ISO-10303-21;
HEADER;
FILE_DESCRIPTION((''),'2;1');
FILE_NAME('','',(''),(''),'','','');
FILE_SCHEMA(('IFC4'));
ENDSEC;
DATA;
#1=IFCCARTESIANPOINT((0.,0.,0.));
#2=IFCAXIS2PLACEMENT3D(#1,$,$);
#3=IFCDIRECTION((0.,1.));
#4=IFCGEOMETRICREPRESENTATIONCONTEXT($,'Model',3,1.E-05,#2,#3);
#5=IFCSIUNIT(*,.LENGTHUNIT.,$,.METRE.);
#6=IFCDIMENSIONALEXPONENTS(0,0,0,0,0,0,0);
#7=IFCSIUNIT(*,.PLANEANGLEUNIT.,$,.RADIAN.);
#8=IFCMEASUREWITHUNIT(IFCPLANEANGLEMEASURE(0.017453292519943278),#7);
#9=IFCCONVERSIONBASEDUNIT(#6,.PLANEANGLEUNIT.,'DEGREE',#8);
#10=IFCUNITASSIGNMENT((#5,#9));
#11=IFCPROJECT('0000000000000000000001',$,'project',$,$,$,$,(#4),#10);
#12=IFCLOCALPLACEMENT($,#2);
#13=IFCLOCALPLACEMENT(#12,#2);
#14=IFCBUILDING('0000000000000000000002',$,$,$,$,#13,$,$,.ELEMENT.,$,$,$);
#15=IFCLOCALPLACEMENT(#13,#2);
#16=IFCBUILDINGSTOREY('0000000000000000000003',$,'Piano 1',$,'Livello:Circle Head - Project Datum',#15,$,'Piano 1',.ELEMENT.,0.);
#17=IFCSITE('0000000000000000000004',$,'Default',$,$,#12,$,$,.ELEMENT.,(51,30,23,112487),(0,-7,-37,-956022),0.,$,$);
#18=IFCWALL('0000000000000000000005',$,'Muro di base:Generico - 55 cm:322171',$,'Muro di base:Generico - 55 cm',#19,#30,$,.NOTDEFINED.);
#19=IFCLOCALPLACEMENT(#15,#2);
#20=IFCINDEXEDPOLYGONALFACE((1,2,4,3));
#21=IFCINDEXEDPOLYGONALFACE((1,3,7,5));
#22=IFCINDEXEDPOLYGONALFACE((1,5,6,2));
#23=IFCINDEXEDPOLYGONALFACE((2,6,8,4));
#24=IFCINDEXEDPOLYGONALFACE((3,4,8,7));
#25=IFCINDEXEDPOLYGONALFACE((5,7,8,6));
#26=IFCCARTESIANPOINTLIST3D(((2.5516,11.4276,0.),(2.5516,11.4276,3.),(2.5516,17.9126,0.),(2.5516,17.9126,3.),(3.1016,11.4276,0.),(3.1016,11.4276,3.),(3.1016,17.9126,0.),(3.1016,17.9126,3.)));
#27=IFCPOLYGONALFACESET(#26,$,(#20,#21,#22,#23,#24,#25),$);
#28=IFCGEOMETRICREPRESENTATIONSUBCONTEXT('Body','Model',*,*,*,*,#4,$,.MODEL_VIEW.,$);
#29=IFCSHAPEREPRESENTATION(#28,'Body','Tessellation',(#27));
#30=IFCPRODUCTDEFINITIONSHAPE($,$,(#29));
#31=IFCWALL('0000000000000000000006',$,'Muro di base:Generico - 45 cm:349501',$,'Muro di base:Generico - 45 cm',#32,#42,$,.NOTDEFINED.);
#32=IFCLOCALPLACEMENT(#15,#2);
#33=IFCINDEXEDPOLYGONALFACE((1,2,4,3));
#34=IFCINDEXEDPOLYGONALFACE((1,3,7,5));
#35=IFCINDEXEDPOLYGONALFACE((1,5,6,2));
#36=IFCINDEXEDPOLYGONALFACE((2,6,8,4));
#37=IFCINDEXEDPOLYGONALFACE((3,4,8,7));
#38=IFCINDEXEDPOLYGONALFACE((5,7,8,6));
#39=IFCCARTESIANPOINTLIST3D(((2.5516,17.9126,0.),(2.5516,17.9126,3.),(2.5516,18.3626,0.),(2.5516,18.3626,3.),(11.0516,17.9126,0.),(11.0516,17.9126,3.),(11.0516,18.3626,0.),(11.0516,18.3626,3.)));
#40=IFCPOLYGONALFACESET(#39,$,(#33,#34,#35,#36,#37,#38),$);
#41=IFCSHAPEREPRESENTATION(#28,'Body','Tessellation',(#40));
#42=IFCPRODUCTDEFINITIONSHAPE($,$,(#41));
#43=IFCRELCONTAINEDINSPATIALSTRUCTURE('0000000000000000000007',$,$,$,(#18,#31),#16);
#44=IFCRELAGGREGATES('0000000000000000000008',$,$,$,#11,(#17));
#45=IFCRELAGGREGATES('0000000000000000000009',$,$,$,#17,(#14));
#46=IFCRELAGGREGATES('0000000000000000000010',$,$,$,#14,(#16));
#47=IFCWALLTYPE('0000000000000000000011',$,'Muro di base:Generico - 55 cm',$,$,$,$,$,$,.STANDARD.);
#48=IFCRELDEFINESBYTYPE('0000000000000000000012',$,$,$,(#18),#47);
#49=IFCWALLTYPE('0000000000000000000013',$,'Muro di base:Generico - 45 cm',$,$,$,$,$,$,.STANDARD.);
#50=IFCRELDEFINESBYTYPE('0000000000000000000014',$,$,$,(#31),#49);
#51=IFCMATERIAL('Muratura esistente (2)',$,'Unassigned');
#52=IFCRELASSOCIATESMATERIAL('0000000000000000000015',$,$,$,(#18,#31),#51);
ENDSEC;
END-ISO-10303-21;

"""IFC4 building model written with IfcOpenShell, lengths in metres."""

from ifc_helpers import new_model, entity, si_unit, converted_unit, direction, frame, origin, place, context, subcontext, project, spatial, indexed_curve, outline, extrude, material, type_object, element, save


model = new_model("IFC4")

# Units and contexts
model_context = context("Model", 3, precision=1e-05, world=origin(), true_north=direction((0.0, 1.0)))
body_context = subcontext(model_context, "Body", "Model", "MODEL_VIEW")
ifc_project = project(units=[si_unit("LENGTHUNIT", "METRE"), converted_unit("PLANEANGLEUNIT", "DEGREE", entity("IfcPlaneAngleMeasure", 0.017453292519943278), si_unit("PLANEANGLEUNIT", "RADIAN"), dimensions=[0, 0, 0, 0, 0, 0, 0])], contexts=[model_context])

# Site, building, storey
site_placement = place(None, origin())
site = spatial("IfcSite", under=ifc_project, at=site_placement, Name="Default", CompositionType="ELEMENT", RefLatitude=(51, 30, 23, 112487), RefLongitude=(0, -7, -37, -956022), RefElevation=0.0)
building_placement = place(site_placement, origin())
building = spatial("IfcBuilding", under=site, at=building_placement, CompositionType="ELEMENT")
storey_placement = place(building_placement, origin())
storey = spatial("IfcBuildingStorey", under=building, at=storey_placement, Name="Piano 1", ObjectType="Livello:Circle Head - Project Datum", LongName="Piano 1", CompositionType="ELEMENT", Elevation=0.0)

# Walls
ifc_material = material(Name="Muratura esistente (2)", Category="Unassigned")
wall_type_1 = type_object("IfcWallType", Name="Muro di base:Generico - 55 cm", PredefinedType="STANDARD")
wall_1_placement = place(storey_placement, frame((2.8266, 17.9126, 0.0), z_axis=(0.0, 0.0, 1.0), x_axis=(0.0, -1.0, 0.0)))
element("IfcWall", 1, at=wall_1_placement, inside=storey, type_object=wall_type_1, material=ifc_material, Name="Muro di base:Generico - 55 cm:322171", ObjectType="Muro di base:Generico - 55 cm", PredefinedType="NOTDEFINED", context=body_context, shape_type="SweptSolid", body=[
    extrude(outline(indexed_curve([(6.485, 0.275), (0.0, 0.275), (0.0, -0.275), (6.485, -0.275), (6.485, 0.275)], self_intersect=False)), origin(), (0.0, 0.0, 1.0), 3.0),
])
wall_type_2 = type_object("IfcWallType", Name="Muro di base:Generico - 45 cm", PredefinedType="STANDARD")
wall_2_placement = place(storey_placement, frame((2.5516, 18.1376, 0.0)))
element("IfcWall", 2, at=wall_2_placement, inside=storey, type_object=wall_type_2, material=ifc_material, Name="Muro di base:Generico - 45 cm:349501", ObjectType="Muro di base:Generico - 45 cm", PredefinedType="NOTDEFINED", context=body_context, shape_type="SweptSolid", body=[
    extrude(outline(indexed_curve([(8.5, 0.225), (0.0, 0.225), (0.0, -0.225), (8.5, -0.225), (8.5, 0.225)], self_intersect=False)), origin(), (0.0, 0.0, 1.0), 3.0),
])

save(model, "model.ifc")
